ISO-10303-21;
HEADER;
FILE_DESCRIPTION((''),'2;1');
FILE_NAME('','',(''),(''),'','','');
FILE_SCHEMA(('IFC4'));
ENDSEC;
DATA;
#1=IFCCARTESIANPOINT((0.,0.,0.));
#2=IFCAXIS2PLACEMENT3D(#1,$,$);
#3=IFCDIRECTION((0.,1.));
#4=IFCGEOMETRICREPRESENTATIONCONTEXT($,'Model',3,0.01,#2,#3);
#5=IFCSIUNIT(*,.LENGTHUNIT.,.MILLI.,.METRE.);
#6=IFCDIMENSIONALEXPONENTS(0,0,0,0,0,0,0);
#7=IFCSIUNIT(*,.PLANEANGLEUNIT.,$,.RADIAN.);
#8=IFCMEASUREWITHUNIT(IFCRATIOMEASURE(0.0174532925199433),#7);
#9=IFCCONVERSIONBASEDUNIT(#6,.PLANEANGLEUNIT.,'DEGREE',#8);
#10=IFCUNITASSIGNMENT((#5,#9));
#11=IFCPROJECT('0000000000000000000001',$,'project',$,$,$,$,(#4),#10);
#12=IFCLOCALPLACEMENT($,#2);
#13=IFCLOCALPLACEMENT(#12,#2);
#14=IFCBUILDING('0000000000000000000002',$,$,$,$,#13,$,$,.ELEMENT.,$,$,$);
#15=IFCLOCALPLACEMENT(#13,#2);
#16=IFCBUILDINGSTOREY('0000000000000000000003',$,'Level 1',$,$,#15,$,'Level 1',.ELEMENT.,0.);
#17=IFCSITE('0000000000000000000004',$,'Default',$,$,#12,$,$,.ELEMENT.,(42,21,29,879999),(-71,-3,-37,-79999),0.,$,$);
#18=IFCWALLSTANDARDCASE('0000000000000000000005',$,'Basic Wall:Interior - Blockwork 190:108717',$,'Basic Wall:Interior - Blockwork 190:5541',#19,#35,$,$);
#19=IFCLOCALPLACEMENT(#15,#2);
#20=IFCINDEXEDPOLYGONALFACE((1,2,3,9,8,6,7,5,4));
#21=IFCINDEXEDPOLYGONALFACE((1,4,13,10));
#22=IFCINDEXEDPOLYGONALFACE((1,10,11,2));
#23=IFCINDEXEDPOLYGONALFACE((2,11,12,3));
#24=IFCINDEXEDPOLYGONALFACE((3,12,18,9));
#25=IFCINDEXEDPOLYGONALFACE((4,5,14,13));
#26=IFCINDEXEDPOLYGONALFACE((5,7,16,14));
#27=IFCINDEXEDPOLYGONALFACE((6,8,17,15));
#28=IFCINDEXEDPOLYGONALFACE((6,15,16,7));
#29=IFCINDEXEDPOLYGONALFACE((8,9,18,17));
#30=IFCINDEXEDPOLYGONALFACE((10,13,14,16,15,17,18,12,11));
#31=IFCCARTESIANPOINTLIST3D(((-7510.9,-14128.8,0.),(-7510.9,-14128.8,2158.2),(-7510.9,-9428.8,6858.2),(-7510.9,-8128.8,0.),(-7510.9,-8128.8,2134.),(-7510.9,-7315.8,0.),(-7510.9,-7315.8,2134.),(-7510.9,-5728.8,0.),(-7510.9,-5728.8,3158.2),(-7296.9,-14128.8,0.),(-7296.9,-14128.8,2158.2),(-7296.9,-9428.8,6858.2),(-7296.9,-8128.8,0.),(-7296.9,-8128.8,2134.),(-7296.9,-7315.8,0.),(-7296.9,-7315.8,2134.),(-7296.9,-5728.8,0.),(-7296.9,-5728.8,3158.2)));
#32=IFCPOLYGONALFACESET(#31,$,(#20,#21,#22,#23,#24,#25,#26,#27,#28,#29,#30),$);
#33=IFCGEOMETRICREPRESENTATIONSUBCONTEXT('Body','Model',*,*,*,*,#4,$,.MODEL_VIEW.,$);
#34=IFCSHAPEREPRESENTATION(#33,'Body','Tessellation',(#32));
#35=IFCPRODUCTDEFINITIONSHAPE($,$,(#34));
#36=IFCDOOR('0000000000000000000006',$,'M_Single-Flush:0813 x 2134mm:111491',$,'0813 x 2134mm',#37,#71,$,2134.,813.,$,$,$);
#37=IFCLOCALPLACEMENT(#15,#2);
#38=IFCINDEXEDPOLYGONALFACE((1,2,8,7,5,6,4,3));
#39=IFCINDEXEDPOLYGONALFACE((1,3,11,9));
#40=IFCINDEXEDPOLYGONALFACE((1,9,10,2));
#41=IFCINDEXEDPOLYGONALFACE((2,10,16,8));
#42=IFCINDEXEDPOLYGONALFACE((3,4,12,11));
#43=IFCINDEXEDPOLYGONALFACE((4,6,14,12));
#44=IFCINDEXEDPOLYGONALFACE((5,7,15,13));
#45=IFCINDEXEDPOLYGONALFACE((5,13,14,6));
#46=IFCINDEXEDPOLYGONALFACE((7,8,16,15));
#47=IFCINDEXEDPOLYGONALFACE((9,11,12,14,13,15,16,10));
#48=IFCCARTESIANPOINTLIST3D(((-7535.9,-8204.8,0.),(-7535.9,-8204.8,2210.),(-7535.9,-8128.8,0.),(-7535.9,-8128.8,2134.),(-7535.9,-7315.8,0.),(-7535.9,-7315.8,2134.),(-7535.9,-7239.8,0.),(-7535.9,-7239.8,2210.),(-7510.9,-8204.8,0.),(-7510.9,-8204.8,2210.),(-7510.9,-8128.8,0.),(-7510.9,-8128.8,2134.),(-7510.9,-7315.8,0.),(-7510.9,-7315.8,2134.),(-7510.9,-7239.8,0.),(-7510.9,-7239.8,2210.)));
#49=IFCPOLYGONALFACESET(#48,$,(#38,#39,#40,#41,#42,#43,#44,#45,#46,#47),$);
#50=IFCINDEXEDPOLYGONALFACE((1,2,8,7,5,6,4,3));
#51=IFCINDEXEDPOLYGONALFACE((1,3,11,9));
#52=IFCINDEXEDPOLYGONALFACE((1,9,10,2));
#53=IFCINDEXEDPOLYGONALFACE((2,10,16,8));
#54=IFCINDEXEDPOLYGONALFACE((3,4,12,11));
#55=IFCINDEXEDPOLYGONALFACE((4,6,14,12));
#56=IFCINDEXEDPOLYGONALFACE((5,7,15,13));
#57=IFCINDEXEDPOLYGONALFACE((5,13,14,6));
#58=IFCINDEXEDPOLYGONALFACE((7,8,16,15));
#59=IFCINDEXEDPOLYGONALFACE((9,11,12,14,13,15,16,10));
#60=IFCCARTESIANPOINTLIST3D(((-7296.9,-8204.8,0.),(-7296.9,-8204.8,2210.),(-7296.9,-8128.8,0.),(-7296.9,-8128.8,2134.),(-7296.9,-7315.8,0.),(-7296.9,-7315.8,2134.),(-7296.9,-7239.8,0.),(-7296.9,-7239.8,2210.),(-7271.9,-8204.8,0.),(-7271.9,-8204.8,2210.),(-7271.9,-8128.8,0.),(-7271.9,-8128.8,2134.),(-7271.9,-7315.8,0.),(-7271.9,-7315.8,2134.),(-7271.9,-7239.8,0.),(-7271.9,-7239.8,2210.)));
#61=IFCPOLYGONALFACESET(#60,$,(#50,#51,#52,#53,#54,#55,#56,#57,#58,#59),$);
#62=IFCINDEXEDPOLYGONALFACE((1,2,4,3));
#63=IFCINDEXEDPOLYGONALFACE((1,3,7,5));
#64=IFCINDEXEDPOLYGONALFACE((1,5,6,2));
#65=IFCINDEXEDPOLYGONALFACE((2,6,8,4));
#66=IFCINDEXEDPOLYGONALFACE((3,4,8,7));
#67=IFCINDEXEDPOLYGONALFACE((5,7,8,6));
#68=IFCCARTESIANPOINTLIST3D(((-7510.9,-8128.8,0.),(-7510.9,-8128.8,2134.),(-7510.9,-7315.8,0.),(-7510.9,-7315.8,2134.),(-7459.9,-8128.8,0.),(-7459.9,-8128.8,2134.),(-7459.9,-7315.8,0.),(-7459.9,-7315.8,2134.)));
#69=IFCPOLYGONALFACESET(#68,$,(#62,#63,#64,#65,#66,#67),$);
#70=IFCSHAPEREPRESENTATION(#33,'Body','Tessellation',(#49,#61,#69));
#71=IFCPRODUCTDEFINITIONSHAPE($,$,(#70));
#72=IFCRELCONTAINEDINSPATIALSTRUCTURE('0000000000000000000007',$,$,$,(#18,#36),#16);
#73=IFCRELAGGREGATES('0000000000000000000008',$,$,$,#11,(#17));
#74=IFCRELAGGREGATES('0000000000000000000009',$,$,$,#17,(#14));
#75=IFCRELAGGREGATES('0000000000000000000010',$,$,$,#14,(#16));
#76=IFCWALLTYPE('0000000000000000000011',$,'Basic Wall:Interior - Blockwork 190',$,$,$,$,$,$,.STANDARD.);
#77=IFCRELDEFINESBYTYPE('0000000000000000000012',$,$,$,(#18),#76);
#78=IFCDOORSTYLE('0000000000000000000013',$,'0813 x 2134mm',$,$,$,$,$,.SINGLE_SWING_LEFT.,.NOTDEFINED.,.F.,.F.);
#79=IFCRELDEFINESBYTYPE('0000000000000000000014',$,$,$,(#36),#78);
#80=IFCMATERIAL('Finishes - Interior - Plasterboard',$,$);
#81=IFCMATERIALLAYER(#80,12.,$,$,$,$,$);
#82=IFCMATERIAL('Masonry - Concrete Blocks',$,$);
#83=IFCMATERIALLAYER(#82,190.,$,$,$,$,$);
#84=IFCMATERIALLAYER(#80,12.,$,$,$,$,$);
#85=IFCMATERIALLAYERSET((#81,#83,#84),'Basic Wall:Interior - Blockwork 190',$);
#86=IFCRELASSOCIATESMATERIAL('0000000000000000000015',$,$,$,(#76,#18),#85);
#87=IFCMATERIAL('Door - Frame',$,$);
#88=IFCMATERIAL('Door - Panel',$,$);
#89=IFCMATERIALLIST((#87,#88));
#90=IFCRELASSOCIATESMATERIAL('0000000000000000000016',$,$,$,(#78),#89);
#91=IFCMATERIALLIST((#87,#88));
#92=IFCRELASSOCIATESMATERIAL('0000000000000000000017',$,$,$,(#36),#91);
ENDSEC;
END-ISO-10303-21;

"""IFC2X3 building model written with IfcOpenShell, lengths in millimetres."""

from ifc_helpers import new_model, entity, si_unit, converted_unit, direction, frame, frame_2d, origin, place, context, subcontext, project, spatial, polyline, rectangle, outline, extrude, clip, bounded_halfspace, source, transform, mapped, material, material_list, layer, layer_set, layer_usage, type_object, type_shapes, element, fill, save


model = new_model("IFC2X3")

# Units and contexts
model_context = context("Model", 3, precision=0.01, world=origin(), true_north=direction((0.0, 1.0)))
body_context = subcontext(model_context, "Body", "Model", "MODEL_VIEW")
ifc_project = project(units=[si_unit("LENGTHUNIT", "METRE", prefix="MILLI"), converted_unit("PLANEANGLEUNIT", "DEGREE", entity("IfcRatioMeasure", 0.0174532925199433), si_unit("PLANEANGLEUNIT", "RADIAN"), dimensions=[0, 0, 0, 0, 0, 0, 0])], contexts=[model_context])

# Site, building, storey
site_placement = place(None, origin())
site = spatial("IfcSite", under=ifc_project, at=site_placement, Name="Default", CompositionType="ELEMENT", RefLatitude=(42, 21, 29, 879999), RefLongitude=(-71, -3, -37, -79999), RefElevation=0.0)
building_placement = place(site_placement, origin())
building = spatial("IfcBuilding", under=site, at=building_placement, CompositionType="ELEMENT")
storey_placement = place(building_placement, origin())
storey = spatial("IfcBuildingStorey", under=building, at=storey_placement, Name="Level 1", LongName="Level 1", CompositionType="ELEMENT", Elevation=0.0)

# Shared definitions
ifc_material_1 = material(Name="Door - Frame")
ifc_material_2 = material(Name="Door - Panel")

# Shared definitions
ifc_material_3 = material(Name="Finishes - Interior - Plasterboard")

# Wall, opening, door
ifc_layer_1 = layer(ifc_material_3, 12.0)
ifc_material_4 = material(Name="Masonry - Concrete Blocks")
ifc_layer_2 = layer(ifc_material_4, 190.0)
ifc_layer_3 = layer(ifc_material_3, 12.0)
ifc_layer_set_1 = layer_set([ifc_layer_1, ifc_layer_2, ifc_layer_3], Name="Basic Wall:Interior - Blockwork 190")
wall_type_1 = type_object("IfcWallType", Name="Basic Wall:Interior - Blockwork 190", PredefinedType="STANDARD", material=ifc_layer_set_1)
ifc_material_list_1 = material_list([ifc_material_1, ifc_material_2])
door_style_1 = type_object("IfcDoorStyle", Name="0813 x 2134mm", ConstructionType="NOTDEFINED", OperationType="SINGLE_SWING_LEFT", ParameterTakesPrecedence=False, Sizeable=False, material=ifc_material_list_1)
shared_shape_1 = source(origin(), body_context, "Body", "SweptSolid", [
    extrude(outline(polyline([(-482.5, -1124.0), (482.5, -1124.0), (482.5, 1086.0), (406.5, 1086.0), (406.5, -1048.0), (-406.5, -1048.0), (-406.5, 1086.0), (-482.5, 1086.0), (-482.5, -1124.0)])), frame((406.5, 239.0, 1086.0), z_axis=(0.0, -1.0, 0.0), x_axis=(-1.0, 0.0, 0.0)), (0.0, 0.0, 1.0), 25.0),
    extrude(outline(polyline([(-1124.0, -482.5), (1086.0, -482.5), (1086.0, -406.5), (-1048.0, -406.5), (-1048.0, 406.5), (1086.0, 406.5), (1086.0, 482.5), (-1124.0, 482.5), (-1124.0, -482.5)])), frame((406.5, 0.0, 1086.0), z_axis=(0.0, -1.0, 0.0), x_axis=(0.0, 0.0, -1.0)), (0.0, 0.0, 1.0), 25.0),
    extrude(rectangle(XDim=813.0, YDim=51.0, at=frame_2d((0.0, 0.0), x_axis=(1.0, 0.0))), frame((406.5, 188.5, 0.0)), (0.0, 0.0, 1.0), 2134.0),
])
type_shapes(door_style_1, [shared_shape_1])
ifc_layer_usage_1 = layer_usage(ifc_layer_set_1, "AXIS2", "NEGATIVE", 107.0)
wall_1_placement = place(storey_placement, frame((-7403.9, -5728.8, 0.0), z_axis=(0.0, 0.0, 1.0), x_axis=(0.0, -1.0, 0.0)))
wall_1 = element("IfcWallStandardCase", 1, at=wall_1_placement, inside=storey, type_object=wall_type_1, material=ifc_layer_usage_1, Name="Basic Wall:Interior - Blockwork 190:108717", ObjectType="Basic Wall:Interior - Blockwork 190:5541", context=body_context, shape_type="Clipping", body=[
    clip(clip(extrude(rectangle(XDim=8400.0, YDim=214.0, at=frame_2d((4200.0, 0.0), x_axis=(-1.0, 0.0))), origin(), (0.0, 0.0, 1.0), 6858.2), bounded_halfspace(frame((3700.0, -107.0, 6858.2), z_axis=(-0.707107, 0.0, -0.707107), x_axis=(0.0, -1.0, 0.0)), True, frame((3700.0, -107.0, 6858.2)), polyline([(0.0, 0.0), (4700.0, 0.0), (4700.0, 214.0), (0.0, 214.0), (0.0, 0.0)]))), bounded_halfspace(frame((0.0, -107.0, 3158.2), z_axis=(0.707107, 0.0, -0.707107), x_axis=(0.0, -1.0, 0.0)), True, frame((0.0, -107.0, 3158.2)), polyline([(0.0, 0.0), (3700.0, 0.0), (3700.0, 214.0), (0.0, 214.0), (0.0, 207.0), (0.0, 0.0)]))),
])
opening_1_placement = place(wall_1_placement, frame((2400.0, 107.0, 0.0)))
opening_1 = element("IfcOpeningElement", 2, at=opening_1_placement, cuts=wall_1, ObjectType="Opening", context=body_context, shape_type="SweptSolid", body=[
    extrude(rectangle(XDim=813.0, YDim=2134.0, at=frame_2d((1067.0, 406.5), x_axis=(0.0, -1.0))), frame((0.0, 0.0, 0.0), z_axis=(0.0, -1.0, 0.0), x_axis=(0.0, 0.0, 1.0)), (0.0, 0.0, 1.0), 214.0),
])
ifc_material_list_2 = material_list([ifc_material_1, ifc_material_2])
door_1_placement = place(opening_1_placement, frame((0.0, 0.0, 0.0), z_axis=(0.0, 0.0, 1.0), x_axis=(-1.0, 0.0, 0.0)))
door_1 = element("IfcDoor", 3, at=door_1_placement, inside=storey, type_object=door_style_1, material=ifc_material_list_2, Name="M_Single-Flush:0813 x 2134mm:111491", ObjectType="0813 x 2134mm", OverallHeight=2134.0, OverallWidth=813.0, context=body_context, shape_type="MappedRepresentation", body=[
    mapped(shared_shape_1, transform((0.0, 0.0, 0.0), scale=1.0)),
])
fill(opening_1, door_1)

save(model, "model.ifc")
